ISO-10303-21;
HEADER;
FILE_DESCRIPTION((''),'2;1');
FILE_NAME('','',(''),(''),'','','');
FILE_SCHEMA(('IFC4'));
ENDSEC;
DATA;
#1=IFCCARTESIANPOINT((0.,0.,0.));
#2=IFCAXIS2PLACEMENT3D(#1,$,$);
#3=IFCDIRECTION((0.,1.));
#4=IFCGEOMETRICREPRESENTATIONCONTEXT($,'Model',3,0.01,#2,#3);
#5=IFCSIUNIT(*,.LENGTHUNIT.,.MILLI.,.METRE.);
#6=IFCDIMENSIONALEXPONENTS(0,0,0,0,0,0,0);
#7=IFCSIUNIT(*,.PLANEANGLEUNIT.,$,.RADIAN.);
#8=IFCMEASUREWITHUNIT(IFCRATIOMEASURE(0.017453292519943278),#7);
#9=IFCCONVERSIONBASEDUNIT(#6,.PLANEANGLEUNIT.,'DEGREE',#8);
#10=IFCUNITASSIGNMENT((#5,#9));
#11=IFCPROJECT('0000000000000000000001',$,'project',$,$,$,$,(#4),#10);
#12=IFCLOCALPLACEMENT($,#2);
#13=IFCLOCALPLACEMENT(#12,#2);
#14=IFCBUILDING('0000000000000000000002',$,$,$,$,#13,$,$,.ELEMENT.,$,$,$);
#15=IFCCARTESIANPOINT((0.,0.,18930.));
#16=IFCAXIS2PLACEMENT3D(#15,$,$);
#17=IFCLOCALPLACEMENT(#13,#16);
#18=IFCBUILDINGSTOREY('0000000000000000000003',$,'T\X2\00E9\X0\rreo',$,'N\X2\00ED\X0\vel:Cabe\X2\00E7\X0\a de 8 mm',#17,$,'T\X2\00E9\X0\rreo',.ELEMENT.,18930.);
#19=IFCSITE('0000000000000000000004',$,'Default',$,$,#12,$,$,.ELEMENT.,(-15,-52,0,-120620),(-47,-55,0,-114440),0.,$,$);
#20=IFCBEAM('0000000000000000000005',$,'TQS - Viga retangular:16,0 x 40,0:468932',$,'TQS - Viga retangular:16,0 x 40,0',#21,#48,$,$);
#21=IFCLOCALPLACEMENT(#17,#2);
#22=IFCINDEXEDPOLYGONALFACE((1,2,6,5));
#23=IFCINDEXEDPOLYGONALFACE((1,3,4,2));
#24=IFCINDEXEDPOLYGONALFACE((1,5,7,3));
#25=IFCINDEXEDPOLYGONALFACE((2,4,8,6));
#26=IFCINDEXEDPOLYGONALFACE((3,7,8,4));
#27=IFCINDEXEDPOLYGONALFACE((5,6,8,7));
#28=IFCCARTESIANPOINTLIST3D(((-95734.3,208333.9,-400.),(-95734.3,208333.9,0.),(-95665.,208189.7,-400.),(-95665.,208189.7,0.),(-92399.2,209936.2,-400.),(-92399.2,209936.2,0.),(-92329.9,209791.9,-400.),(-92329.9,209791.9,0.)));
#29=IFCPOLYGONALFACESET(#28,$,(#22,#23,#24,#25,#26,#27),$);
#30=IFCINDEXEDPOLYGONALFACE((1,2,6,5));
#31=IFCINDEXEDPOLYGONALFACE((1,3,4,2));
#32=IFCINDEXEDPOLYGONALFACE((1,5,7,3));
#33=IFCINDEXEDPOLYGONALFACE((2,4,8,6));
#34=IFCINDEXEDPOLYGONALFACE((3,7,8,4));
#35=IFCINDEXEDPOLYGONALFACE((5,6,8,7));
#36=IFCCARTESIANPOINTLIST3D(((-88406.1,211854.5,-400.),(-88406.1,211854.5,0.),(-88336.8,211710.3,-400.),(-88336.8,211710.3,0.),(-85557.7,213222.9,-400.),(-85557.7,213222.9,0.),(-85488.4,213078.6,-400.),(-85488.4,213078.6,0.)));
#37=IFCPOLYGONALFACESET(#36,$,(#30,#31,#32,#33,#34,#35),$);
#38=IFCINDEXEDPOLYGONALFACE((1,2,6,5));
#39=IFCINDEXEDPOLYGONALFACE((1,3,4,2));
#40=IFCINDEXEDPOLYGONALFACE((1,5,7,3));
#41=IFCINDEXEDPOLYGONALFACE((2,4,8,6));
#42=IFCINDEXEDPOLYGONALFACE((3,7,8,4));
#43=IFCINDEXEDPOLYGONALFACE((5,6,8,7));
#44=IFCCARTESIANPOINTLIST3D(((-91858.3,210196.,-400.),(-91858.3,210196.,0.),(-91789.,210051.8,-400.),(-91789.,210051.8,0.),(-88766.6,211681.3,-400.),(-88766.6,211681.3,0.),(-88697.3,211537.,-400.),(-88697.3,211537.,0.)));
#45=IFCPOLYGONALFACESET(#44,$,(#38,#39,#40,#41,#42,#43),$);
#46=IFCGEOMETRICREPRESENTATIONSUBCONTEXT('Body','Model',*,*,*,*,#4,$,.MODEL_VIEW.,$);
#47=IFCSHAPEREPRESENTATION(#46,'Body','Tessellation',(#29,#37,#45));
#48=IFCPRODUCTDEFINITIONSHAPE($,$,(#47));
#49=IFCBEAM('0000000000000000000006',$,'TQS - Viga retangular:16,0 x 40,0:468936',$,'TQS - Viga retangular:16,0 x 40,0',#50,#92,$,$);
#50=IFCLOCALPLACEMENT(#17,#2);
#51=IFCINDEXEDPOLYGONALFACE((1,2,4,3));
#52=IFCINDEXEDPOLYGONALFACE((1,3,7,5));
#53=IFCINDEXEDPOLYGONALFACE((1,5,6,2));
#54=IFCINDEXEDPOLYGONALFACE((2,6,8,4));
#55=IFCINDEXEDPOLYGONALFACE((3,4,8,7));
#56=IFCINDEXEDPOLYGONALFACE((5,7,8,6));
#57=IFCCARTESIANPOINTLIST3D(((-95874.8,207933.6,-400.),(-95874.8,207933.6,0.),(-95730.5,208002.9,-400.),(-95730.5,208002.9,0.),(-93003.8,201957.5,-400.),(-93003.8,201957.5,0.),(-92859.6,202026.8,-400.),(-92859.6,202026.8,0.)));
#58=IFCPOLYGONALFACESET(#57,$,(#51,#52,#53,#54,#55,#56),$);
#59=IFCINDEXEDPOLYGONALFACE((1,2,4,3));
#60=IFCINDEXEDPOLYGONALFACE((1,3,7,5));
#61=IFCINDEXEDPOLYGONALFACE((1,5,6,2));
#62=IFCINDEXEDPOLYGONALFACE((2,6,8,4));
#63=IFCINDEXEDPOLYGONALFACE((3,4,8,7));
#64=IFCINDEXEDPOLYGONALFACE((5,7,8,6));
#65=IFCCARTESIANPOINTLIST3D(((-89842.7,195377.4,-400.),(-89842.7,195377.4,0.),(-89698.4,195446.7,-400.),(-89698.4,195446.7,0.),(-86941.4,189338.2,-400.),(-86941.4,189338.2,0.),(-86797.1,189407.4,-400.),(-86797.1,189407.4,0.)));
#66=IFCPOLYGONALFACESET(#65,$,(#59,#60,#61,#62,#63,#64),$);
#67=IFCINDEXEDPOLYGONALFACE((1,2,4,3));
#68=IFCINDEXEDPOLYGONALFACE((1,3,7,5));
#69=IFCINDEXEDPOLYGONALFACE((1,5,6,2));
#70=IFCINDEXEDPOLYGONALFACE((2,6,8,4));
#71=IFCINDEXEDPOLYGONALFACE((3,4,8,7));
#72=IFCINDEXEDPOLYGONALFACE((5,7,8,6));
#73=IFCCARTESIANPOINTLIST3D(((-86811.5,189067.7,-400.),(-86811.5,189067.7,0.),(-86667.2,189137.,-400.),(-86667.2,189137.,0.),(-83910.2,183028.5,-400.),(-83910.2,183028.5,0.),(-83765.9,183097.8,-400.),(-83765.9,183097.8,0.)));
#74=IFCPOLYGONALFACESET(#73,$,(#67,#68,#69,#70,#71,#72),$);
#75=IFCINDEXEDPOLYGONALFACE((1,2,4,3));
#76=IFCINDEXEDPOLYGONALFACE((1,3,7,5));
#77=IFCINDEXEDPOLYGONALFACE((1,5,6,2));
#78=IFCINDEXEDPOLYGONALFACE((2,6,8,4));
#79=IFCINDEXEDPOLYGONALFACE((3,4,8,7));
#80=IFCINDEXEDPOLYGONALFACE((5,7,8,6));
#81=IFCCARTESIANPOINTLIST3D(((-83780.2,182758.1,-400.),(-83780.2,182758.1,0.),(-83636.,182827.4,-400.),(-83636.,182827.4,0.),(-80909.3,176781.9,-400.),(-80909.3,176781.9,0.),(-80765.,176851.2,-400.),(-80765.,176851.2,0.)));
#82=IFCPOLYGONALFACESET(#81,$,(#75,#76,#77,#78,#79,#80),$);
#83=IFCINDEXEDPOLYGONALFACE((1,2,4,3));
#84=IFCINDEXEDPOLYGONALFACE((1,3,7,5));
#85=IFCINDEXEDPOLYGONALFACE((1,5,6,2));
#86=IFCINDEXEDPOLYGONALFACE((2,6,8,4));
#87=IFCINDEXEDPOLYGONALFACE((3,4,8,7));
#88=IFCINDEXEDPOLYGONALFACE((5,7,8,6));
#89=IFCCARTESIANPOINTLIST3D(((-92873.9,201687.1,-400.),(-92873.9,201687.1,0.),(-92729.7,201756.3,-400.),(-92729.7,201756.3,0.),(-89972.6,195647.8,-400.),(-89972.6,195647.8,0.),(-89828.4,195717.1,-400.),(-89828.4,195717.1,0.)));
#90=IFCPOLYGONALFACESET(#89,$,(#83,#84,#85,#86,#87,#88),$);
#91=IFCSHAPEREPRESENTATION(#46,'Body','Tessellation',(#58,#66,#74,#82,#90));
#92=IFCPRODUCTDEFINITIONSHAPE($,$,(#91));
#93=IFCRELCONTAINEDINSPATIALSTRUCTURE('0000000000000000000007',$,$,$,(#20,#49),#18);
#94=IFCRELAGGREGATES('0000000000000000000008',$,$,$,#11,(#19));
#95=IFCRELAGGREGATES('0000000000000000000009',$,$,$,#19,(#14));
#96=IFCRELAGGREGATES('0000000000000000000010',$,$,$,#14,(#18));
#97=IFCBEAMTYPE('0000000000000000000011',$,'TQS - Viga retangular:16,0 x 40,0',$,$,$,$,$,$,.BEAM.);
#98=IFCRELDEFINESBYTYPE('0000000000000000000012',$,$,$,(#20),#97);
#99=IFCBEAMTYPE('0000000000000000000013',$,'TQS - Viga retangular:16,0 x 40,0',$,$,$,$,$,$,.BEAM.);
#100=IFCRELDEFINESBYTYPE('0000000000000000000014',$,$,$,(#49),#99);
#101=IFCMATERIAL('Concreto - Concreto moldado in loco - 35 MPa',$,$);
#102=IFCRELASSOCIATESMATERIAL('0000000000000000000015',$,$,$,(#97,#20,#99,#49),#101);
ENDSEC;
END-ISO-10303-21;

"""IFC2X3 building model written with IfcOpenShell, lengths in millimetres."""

from ifc_helpers import new_model, entity, si_unit, converted_unit, direction, frame, frame_2d, origin, origin_2d_with_axis, place, context, subcontext, project, spatial, rectangle, extrude, source, transform, mapped, material, type_object, type_shapes, element, save


model = new_model("IFC2X3")

# Units and contexts
model_context = context("Model", 3, precision=0.01, world=origin(), true_north=direction((0.0, 1.0)))
body_context = subcontext(model_context, "Body", "Model", "MODEL_VIEW")
ifc_project = project(units=[si_unit("LENGTHUNIT", "METRE", prefix="MILLI"), converted_unit("PLANEANGLEUNIT", "DEGREE", entity("IfcRatioMeasure", 0.017453292519943278), si_unit("PLANEANGLEUNIT", "RADIAN"), dimensions=[0, 0, 0, 0, 0, 0, 0])], contexts=[model_context])

# Site, building, storey
site_placement = place(None, origin())
site = spatial("IfcSite", under=ifc_project, at=site_placement, Name="Default", CompositionType="ELEMENT", RefLatitude=(-15, -52, 0, -120620), RefLongitude=(-47, -55, 0, -114440), RefElevation=0.0)
building_placement = place(site_placement, origin())
building = spatial("IfcBuilding", under=site, at=building_placement, CompositionType="ELEMENT")
storey_placement = place(building_placement, frame((0.0, 0.0, 18930.0)))
storey = spatial("IfcBuildingStorey", under=building, at=storey_placement, Name="Térreo", ObjectType="Nível:Cabeça de 8 mm", LongName="Térreo", CompositionType="ELEMENT", Elevation=18930.0)

# Shared definitions
ifc_material = material(Name="Concreto - Concreto moldado in loco - 35 MPa")

# Beams
beam_type_1 = type_object("IfcBeamType", Name="TQS - Viga retangular:16,0 x 40,0", PredefinedType="BEAM", material=ifc_material)
shared_shape_1 = source(origin(), body_context, "Body", "SweptSolid", [
    extrude(rectangle(XDim=400.0, YDim=160.0, at=frame_2d((0.0, 0.0), x_axis=(1.0, 0.0))), frame((-92364.5, 209864.0, 18730.0), z_axis=(-0.90138, -0.43303, 0.0), x_axis=(0.0, 0.0, -1.0)), (0.0, 0.0, 1.0), 3700.0),
    extrude(rectangle(XDim=400.0, YDim=160.0, at=frame_2d((0.0, 0.0), x_axis=(1.0, 0.0))), frame((-85523.0, 213150.7, 18730.0), z_axis=(-0.90138, -0.43303, 0.0), x_axis=(0.0, 0.0, -1.0)), (0.0, 0.0, 1.0), 3160.0),
    extrude(rectangle(XDim=400.0, YDim=160.0, at=frame_2d((0.0, 0.0), x_axis=(1.0, 0.0))), frame((-88732.0, 211609.2, 18730.0), z_axis=(-0.90138, -0.43303, 0.0), x_axis=(0.0, 0.0, -1.0)), (0.0, 0.0, 1.0), 3430.0),
])
type_shapes(beam_type_1, [shared_shape_1])
beam_1_placement = place(storey_placement, frame((0.0, 0.0, -18930.0)))
element("IfcBeam", 1, at=beam_1_placement, inside=storey, type_object=beam_type_1, material=ifc_material, Name="TQS - Viga retangular:16,0 x 40,0:468932", ObjectType="TQS - Viga retangular:16,0 x 40,0", context=body_context, shape_type="MappedRepresentation", body=[
    mapped(shared_shape_1, transform((0.0, 0.0, 0.0), scale=1.0)),
])
beam_type_2 = type_object("IfcBeamType", Name="TQS - Viga retangular:16,0 x 40,0", PredefinedType="BEAM", material=ifc_material)
shared_shape_2 = source(origin(), body_context, "Body", "SweptSolid", [
    extrude(rectangle(XDim=400.0, YDim=160.0, at=origin_2d_with_axis()), frame((-92931.7, 201992.1, 18730.0), z_axis=(-0.43303, 0.90138, 0.0), x_axis=(0.0, 0.0, 1.0)), (0.0, 0.0, 1.0), 6630.0),
    extrude(rectangle(XDim=400.0, YDim=160.0, at=frame_2d((0.0, 0.0), x_axis=(1.0, 0.0))), frame((-86869.3, 189372.8, 18730.0), z_axis=(-0.43303, 0.90138, 0.0), x_axis=(0.0, 0.0, 1.0)), (0.0, 0.0, 1.0), 6700.0),
    extrude(rectangle(XDim=400.0, YDim=160.0, at=frame_2d((0.0, 0.0), x_axis=(1.0, 0.0))), frame((-83838.0, 183063.1, 18730.0), z_axis=(-0.43303, 0.90138, 0.0), x_axis=(0.0, 0.0, 1.0)), (0.0, 0.0, 1.0), 6700.0),
    extrude(rectangle(XDim=400.0, YDim=160.0, at=origin_2d_with_axis()), frame((-80837.1, 176816.6, 18730.0), z_axis=(-0.43303, 0.90138, 0.0), x_axis=(0.0, 0.0, 1.0)), (0.0, 0.0, 1.0), 6630.0),
    extrude(rectangle(XDim=400.0, YDim=160.0, at=frame_2d((0.0, 0.0), x_axis=(1.0, 0.0))), frame((-89900.5, 195682.5, 18730.0), z_axis=(-0.43303, 0.90138, 0.0), x_axis=(0.0, 0.0, 1.0)), (0.0, 0.0, 1.0), 6700.0),
])
type_shapes(beam_type_2, [shared_shape_2])
beam_2_placement = place(storey_placement, frame((0.0, 0.0, -18930.0)))
element("IfcBeam", 2, at=beam_2_placement, inside=storey, type_object=beam_type_2, material=ifc_material, Name="TQS - Viga retangular:16,0 x 40,0:468936", ObjectType="TQS - Viga retangular:16,0 x 40,0", context=body_context, shape_type="MappedRepresentation", body=[
    mapped(shared_shape_2, transform((0.0, 0.0, 0.0), scale=1.0)),
])

save(model, "model.ifc")
